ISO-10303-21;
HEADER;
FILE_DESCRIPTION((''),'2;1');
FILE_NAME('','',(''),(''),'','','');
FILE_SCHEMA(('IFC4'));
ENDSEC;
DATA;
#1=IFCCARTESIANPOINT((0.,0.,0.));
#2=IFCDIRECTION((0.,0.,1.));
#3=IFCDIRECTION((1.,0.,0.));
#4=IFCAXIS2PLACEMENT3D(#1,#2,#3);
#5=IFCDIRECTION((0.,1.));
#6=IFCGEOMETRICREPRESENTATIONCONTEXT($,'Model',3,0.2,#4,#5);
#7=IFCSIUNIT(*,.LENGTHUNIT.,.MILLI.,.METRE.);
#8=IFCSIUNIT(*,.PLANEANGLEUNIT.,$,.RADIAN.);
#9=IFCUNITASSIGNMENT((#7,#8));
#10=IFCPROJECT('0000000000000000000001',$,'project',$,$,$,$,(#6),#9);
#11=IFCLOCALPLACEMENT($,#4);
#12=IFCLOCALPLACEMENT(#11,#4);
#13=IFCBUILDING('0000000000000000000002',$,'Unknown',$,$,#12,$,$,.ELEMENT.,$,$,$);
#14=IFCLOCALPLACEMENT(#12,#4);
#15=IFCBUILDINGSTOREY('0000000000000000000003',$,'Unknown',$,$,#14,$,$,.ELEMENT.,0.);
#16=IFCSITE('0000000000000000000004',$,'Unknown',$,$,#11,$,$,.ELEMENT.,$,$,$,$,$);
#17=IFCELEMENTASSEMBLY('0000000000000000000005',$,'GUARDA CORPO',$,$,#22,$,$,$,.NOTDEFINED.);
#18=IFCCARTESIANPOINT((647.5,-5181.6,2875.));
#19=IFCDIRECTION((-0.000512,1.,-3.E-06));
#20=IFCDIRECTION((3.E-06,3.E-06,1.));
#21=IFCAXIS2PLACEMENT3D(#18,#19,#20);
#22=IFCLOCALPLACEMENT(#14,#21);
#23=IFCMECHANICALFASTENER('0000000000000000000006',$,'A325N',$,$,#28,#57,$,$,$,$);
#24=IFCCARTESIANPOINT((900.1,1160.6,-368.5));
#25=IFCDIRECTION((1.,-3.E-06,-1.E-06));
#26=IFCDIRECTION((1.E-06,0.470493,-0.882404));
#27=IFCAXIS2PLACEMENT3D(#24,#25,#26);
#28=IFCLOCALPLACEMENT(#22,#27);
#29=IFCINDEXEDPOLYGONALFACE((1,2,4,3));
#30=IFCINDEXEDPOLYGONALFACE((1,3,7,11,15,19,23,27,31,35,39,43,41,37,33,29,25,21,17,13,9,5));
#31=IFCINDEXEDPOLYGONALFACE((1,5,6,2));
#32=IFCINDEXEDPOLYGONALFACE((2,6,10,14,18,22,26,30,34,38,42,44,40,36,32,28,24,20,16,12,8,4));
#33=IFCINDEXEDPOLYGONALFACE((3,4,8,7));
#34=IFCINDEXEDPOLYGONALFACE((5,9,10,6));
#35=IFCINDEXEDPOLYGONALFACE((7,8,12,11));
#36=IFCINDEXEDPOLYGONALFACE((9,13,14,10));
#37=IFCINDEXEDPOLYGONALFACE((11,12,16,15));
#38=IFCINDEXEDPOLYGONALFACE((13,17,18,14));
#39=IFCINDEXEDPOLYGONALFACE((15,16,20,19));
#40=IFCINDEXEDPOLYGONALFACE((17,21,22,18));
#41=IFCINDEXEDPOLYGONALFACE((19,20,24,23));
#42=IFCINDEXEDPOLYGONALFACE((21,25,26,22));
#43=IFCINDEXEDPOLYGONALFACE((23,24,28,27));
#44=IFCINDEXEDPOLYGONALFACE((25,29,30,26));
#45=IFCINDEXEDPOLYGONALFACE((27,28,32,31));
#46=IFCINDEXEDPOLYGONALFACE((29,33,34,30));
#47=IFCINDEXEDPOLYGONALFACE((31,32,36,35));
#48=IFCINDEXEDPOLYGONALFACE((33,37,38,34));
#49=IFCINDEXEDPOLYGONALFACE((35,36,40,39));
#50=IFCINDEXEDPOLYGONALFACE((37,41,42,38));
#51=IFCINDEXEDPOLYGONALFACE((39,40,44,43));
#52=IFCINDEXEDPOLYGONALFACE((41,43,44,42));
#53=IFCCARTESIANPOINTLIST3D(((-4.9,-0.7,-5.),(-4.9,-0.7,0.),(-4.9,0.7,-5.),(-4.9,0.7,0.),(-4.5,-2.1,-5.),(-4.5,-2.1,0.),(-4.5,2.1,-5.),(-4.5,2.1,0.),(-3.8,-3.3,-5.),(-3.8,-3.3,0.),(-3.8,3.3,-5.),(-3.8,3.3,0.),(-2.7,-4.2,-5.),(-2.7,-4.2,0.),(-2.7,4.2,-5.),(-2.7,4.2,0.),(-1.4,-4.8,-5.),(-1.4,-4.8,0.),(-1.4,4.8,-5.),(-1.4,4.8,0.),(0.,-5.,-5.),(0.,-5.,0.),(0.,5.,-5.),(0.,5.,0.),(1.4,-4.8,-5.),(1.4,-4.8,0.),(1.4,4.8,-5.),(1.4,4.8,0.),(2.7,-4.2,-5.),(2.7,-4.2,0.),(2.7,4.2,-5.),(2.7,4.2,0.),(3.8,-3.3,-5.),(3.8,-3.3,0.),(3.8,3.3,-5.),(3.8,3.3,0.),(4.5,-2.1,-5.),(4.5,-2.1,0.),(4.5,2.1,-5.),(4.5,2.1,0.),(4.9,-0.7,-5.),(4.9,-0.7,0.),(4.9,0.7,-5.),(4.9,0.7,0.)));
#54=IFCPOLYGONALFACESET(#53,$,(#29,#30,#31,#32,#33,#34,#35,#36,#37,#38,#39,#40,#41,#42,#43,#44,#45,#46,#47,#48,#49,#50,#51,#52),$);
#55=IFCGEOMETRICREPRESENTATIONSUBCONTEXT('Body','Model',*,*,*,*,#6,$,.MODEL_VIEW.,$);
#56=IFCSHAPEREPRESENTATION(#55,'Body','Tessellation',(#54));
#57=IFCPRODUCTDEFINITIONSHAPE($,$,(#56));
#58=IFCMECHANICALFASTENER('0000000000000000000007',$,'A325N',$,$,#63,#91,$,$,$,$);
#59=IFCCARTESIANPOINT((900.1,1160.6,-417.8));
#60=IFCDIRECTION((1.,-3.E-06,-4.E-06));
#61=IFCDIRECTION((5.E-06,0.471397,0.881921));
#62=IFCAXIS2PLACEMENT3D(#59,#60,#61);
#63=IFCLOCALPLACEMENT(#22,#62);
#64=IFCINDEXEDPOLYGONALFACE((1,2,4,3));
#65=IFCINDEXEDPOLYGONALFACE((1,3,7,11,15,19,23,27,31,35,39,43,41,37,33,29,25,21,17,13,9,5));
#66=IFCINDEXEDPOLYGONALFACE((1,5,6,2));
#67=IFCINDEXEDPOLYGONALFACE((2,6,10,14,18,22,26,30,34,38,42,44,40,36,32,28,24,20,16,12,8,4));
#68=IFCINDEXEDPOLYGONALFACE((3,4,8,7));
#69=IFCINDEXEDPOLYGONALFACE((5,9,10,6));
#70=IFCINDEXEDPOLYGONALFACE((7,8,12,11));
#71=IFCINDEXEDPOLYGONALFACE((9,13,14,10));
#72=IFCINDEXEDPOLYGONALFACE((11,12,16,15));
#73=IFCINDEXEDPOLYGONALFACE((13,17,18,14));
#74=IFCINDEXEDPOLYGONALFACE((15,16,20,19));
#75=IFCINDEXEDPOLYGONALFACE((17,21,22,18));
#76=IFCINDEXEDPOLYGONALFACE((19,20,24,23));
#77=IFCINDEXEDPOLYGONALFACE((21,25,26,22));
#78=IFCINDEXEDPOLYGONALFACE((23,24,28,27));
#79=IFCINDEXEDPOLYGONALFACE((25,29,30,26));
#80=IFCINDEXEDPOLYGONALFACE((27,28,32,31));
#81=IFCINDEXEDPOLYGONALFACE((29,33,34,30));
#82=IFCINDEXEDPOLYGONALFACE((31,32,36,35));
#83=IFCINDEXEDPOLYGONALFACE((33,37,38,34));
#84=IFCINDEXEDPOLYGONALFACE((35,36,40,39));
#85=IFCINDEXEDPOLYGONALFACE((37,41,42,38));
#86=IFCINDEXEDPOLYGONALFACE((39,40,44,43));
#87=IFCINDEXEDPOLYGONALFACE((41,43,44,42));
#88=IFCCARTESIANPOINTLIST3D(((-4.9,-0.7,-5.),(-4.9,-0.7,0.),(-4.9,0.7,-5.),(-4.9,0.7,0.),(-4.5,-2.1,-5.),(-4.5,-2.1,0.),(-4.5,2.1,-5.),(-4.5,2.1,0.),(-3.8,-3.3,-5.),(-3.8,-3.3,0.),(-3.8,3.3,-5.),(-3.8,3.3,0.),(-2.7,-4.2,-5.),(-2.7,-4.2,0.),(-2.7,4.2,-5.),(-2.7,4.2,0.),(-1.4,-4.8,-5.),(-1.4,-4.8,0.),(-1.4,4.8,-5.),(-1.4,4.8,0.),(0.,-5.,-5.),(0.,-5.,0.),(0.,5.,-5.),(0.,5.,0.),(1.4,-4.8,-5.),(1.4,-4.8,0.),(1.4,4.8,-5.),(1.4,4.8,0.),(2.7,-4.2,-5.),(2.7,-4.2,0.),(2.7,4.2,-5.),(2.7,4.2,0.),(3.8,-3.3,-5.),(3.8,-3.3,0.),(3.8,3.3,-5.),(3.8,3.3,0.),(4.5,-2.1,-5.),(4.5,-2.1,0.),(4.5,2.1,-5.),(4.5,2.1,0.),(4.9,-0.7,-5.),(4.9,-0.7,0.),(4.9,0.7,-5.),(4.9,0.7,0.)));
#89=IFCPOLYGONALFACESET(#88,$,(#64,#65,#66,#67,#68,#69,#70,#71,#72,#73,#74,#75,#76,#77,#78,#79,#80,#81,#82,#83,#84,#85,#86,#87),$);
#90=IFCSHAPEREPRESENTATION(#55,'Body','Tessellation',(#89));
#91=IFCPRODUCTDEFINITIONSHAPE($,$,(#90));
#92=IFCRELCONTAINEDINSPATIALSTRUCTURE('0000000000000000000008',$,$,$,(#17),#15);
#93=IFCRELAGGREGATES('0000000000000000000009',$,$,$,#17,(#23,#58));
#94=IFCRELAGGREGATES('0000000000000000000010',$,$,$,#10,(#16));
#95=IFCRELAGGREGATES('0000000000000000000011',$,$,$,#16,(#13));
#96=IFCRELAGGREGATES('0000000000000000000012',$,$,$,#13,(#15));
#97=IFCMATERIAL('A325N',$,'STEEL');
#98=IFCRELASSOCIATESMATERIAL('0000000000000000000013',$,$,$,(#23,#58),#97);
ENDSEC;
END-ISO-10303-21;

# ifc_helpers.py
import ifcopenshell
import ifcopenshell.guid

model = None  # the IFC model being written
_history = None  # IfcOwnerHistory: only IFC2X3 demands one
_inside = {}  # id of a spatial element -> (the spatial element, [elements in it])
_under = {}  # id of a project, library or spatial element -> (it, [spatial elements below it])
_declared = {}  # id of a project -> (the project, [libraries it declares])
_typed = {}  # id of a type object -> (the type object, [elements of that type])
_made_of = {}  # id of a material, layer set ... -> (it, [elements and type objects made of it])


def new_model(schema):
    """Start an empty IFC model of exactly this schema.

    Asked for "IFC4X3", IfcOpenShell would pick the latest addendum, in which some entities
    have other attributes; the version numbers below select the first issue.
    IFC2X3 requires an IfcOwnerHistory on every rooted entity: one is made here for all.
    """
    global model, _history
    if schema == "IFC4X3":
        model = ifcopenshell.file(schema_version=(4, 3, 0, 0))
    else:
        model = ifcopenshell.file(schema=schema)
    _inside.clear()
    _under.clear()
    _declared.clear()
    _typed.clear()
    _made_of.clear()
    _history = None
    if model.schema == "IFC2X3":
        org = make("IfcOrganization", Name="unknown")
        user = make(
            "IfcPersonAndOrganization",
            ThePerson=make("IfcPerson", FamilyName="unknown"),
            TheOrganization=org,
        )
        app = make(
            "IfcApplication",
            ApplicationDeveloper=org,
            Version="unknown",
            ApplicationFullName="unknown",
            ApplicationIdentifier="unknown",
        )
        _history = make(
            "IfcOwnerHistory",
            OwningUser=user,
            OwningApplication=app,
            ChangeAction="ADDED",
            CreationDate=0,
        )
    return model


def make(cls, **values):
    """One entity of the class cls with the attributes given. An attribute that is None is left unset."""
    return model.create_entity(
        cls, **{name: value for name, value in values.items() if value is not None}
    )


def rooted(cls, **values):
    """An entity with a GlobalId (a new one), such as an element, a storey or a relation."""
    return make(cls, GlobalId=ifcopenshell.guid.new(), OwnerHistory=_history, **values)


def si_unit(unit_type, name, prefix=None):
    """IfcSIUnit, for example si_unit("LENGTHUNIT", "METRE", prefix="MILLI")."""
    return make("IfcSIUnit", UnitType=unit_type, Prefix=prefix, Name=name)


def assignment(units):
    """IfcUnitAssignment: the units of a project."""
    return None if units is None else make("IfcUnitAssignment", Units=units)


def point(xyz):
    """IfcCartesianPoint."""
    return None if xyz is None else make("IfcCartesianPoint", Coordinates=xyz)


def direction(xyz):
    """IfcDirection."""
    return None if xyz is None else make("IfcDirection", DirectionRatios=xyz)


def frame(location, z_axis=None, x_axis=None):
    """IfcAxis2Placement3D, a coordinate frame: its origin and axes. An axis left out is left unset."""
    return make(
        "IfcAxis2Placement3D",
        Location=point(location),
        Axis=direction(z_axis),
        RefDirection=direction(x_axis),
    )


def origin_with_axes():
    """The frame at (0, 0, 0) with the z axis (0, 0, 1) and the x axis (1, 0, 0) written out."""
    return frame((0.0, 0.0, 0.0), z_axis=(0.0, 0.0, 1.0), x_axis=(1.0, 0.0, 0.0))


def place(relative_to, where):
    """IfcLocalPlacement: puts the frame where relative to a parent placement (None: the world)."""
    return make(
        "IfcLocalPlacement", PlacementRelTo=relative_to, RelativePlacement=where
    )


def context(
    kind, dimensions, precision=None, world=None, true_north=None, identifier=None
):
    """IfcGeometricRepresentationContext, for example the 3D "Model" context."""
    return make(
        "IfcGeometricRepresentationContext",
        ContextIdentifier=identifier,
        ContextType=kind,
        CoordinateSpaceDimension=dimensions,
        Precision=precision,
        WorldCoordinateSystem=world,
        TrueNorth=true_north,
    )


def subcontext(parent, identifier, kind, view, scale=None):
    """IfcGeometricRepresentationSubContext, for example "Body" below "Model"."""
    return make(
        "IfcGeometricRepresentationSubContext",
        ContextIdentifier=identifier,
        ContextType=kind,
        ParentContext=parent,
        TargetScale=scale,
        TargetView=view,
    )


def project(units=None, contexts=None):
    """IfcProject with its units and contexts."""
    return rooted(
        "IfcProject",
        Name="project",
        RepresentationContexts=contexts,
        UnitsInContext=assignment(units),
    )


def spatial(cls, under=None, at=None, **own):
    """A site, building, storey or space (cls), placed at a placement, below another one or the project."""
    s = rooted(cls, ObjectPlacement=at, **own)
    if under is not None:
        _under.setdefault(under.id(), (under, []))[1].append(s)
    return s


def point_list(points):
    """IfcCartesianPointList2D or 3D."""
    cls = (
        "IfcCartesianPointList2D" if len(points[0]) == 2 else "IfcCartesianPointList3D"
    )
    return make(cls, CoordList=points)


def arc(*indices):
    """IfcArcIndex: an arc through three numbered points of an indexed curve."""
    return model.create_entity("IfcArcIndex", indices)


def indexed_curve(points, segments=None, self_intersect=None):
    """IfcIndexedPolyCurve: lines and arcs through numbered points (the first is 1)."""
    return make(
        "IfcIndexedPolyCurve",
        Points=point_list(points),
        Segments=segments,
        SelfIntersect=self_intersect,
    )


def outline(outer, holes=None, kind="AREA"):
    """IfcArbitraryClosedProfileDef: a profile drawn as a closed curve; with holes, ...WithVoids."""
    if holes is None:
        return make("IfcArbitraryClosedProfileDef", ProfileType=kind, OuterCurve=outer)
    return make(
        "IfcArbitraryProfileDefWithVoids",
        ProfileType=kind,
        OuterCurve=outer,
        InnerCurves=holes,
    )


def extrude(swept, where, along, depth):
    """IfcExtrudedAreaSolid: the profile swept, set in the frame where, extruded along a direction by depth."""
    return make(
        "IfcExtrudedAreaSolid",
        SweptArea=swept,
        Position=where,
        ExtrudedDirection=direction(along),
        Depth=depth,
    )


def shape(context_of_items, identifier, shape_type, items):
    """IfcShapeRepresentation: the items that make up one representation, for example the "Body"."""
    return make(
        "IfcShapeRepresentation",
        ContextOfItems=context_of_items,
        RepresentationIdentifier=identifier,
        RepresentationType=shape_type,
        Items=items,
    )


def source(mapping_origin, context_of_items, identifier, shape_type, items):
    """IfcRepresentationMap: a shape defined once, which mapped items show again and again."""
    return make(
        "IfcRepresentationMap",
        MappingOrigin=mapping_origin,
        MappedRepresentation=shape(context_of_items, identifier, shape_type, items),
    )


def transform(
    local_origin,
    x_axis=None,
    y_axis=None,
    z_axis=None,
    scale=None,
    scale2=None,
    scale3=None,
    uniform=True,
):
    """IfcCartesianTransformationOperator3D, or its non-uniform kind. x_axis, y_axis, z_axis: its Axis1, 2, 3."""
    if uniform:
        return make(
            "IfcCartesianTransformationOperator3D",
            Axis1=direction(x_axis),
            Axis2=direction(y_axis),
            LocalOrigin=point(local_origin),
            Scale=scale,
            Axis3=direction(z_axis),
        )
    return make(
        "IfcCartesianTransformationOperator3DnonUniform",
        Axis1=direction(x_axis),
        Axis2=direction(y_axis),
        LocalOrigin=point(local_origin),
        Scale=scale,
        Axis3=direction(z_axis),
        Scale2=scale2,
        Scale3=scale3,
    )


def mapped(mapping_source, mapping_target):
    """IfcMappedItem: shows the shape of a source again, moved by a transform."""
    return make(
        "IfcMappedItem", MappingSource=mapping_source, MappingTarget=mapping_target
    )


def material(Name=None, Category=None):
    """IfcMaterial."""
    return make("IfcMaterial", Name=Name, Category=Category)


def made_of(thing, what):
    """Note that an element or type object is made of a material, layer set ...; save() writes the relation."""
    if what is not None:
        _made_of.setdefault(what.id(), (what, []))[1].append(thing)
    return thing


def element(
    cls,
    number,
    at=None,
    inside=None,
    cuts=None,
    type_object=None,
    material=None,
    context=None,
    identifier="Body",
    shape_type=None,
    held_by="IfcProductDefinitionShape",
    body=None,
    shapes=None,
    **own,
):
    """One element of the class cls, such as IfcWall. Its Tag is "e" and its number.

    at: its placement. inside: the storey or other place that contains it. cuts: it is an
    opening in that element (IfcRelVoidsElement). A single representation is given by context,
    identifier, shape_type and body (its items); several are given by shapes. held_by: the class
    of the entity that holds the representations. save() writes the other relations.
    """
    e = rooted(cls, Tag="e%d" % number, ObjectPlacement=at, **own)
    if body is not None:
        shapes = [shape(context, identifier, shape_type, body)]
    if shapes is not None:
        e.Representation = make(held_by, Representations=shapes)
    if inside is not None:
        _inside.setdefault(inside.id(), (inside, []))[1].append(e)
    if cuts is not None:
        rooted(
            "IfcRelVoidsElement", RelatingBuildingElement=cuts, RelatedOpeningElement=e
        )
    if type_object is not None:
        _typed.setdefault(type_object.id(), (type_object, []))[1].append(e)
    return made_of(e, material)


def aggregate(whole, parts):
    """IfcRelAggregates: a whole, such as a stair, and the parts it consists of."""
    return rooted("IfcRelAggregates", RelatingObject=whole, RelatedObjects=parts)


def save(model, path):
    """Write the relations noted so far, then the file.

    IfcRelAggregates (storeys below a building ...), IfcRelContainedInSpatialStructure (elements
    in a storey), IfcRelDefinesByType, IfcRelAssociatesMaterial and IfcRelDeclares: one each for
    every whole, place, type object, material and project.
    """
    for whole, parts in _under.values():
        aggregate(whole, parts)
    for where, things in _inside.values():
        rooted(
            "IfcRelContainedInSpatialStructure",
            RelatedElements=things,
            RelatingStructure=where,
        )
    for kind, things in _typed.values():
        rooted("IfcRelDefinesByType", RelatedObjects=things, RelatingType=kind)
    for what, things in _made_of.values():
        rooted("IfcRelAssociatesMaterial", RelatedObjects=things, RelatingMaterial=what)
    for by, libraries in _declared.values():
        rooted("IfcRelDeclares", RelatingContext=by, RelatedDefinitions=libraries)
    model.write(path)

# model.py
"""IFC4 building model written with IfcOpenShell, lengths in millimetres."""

from ifc_helpers import new_model, si_unit, direction, frame, origin_with_axes, place, context, subcontext, project, spatial, arc, indexed_curve, outline, extrude, source, transform, mapped, material, element, aggregate, save


model = new_model("IFC4")

# Units and contexts
model_context = context("Model", 3, precision=0.2, world=origin_with_axes(), true_north=direction((0.0, 1.0)))
body_context = subcontext(model_context, "Body", "Model", "MODEL_VIEW")
ifc_project = project(units=[si_unit("LENGTHUNIT", "METRE", prefix="MILLI"), si_unit("PLANEANGLEUNIT", "RADIAN")], contexts=[model_context])

# Site, building, storey
site_placement = place(None, origin_with_axes())
site = spatial("IfcSite", under=ifc_project, at=site_placement, Name="Unknown", CompositionType="ELEMENT")
building_placement = place(site_placement, origin_with_axes())
building = spatial("IfcBuilding", under=site, at=building_placement, Name="Unknown", CompositionType="ELEMENT")
storey_placement = place(building_placement, origin_with_axes())
storey = spatial("IfcBuildingStorey", under=building, at=storey_placement, Name="Unknown", CompositionType="ELEMENT", Elevation=0.0)

# Element assembly
assembly_1_placement = place(storey_placement, frame((647.5, -5181.6, 2875.0), z_axis=(-0.000512, 1.0, -0.000003), x_axis=(0.000003, 0.000003, 1.0)))
assembly_1 = element("IfcElementAssembly", 1, at=assembly_1_placement, inside=storey, Name="GUARDA CORPO", PredefinedType="NOTDEFINED")

# Mechanical fasteners
ifc_material_1 = material(Name="A325N", Category="STEEL")
shared_shape_1 = source(origin_with_axes(), body_context, "Body", "SweptSolid", [
    extrude(outline(indexed_curve([(5.0, 0.0), (0.0, 5.0), (-5.0, 0.0), (0.0, -5.0)], segments=[arc(1, 2, 3), arc(3, 4, 1)])), frame((0.0, 0.0, 0.0), z_axis=(0.0, 0.0, -1.0), x_axis=(0.0, 1.0, 0.0)), (0.0, 0.0, 1.0), 5.0),
])
mechanical_fastener_1_placement = place(assembly_1_placement, frame((900.1, 1160.6, -368.5), z_axis=(1.0, -0.000003, -0.000001), x_axis=(0.000001, 0.470493, -0.882404)))
mechanical_fastener_1 = element("IfcMechanicalFastener", 2, at=mechanical_fastener_1_placement, material=ifc_material_1, Name="A325N", context=body_context, shape_type="MappedRepresentation", body=[
    mapped(shared_shape_1, transform((0.0, 0.0, 0.0))),
])
shared_shape_2 = source(origin_with_axes(), body_context, "Body", "SweptSolid", [
    extrude(outline(indexed_curve([(5.0, 0.0), (0.0, 5.0), (-5.0, 0.0), (0.0, -5.0)], segments=[arc(1, 2, 3), arc(3, 4, 1)])), frame((0.0, 0.0, 0.0), z_axis=(0.0, 0.0, -1.0), x_axis=(0.0, 1.0, 0.0)), (0.0, 0.0, 1.0), 5.0),
])
mechanical_fastener_2_placement = place(assembly_1_placement, frame((900.1, 1160.6, -417.8), z_axis=(1.0, -0.000003, -0.000004), x_axis=(0.000005, 0.471397, 0.881921)))
mechanical_fastener_2 = element("IfcMechanicalFastener", 3, at=mechanical_fastener_2_placement, material=ifc_material_1, Name="A325N", context=body_context, shape_type="MappedRepresentation", body=[
    mapped(shared_shape_2, transform((0.0, 0.0, 0.0))),
])
aggregate(assembly_1, [mechanical_fastener_1, mechanical_fastener_2])

save(model, "model.ifc")
